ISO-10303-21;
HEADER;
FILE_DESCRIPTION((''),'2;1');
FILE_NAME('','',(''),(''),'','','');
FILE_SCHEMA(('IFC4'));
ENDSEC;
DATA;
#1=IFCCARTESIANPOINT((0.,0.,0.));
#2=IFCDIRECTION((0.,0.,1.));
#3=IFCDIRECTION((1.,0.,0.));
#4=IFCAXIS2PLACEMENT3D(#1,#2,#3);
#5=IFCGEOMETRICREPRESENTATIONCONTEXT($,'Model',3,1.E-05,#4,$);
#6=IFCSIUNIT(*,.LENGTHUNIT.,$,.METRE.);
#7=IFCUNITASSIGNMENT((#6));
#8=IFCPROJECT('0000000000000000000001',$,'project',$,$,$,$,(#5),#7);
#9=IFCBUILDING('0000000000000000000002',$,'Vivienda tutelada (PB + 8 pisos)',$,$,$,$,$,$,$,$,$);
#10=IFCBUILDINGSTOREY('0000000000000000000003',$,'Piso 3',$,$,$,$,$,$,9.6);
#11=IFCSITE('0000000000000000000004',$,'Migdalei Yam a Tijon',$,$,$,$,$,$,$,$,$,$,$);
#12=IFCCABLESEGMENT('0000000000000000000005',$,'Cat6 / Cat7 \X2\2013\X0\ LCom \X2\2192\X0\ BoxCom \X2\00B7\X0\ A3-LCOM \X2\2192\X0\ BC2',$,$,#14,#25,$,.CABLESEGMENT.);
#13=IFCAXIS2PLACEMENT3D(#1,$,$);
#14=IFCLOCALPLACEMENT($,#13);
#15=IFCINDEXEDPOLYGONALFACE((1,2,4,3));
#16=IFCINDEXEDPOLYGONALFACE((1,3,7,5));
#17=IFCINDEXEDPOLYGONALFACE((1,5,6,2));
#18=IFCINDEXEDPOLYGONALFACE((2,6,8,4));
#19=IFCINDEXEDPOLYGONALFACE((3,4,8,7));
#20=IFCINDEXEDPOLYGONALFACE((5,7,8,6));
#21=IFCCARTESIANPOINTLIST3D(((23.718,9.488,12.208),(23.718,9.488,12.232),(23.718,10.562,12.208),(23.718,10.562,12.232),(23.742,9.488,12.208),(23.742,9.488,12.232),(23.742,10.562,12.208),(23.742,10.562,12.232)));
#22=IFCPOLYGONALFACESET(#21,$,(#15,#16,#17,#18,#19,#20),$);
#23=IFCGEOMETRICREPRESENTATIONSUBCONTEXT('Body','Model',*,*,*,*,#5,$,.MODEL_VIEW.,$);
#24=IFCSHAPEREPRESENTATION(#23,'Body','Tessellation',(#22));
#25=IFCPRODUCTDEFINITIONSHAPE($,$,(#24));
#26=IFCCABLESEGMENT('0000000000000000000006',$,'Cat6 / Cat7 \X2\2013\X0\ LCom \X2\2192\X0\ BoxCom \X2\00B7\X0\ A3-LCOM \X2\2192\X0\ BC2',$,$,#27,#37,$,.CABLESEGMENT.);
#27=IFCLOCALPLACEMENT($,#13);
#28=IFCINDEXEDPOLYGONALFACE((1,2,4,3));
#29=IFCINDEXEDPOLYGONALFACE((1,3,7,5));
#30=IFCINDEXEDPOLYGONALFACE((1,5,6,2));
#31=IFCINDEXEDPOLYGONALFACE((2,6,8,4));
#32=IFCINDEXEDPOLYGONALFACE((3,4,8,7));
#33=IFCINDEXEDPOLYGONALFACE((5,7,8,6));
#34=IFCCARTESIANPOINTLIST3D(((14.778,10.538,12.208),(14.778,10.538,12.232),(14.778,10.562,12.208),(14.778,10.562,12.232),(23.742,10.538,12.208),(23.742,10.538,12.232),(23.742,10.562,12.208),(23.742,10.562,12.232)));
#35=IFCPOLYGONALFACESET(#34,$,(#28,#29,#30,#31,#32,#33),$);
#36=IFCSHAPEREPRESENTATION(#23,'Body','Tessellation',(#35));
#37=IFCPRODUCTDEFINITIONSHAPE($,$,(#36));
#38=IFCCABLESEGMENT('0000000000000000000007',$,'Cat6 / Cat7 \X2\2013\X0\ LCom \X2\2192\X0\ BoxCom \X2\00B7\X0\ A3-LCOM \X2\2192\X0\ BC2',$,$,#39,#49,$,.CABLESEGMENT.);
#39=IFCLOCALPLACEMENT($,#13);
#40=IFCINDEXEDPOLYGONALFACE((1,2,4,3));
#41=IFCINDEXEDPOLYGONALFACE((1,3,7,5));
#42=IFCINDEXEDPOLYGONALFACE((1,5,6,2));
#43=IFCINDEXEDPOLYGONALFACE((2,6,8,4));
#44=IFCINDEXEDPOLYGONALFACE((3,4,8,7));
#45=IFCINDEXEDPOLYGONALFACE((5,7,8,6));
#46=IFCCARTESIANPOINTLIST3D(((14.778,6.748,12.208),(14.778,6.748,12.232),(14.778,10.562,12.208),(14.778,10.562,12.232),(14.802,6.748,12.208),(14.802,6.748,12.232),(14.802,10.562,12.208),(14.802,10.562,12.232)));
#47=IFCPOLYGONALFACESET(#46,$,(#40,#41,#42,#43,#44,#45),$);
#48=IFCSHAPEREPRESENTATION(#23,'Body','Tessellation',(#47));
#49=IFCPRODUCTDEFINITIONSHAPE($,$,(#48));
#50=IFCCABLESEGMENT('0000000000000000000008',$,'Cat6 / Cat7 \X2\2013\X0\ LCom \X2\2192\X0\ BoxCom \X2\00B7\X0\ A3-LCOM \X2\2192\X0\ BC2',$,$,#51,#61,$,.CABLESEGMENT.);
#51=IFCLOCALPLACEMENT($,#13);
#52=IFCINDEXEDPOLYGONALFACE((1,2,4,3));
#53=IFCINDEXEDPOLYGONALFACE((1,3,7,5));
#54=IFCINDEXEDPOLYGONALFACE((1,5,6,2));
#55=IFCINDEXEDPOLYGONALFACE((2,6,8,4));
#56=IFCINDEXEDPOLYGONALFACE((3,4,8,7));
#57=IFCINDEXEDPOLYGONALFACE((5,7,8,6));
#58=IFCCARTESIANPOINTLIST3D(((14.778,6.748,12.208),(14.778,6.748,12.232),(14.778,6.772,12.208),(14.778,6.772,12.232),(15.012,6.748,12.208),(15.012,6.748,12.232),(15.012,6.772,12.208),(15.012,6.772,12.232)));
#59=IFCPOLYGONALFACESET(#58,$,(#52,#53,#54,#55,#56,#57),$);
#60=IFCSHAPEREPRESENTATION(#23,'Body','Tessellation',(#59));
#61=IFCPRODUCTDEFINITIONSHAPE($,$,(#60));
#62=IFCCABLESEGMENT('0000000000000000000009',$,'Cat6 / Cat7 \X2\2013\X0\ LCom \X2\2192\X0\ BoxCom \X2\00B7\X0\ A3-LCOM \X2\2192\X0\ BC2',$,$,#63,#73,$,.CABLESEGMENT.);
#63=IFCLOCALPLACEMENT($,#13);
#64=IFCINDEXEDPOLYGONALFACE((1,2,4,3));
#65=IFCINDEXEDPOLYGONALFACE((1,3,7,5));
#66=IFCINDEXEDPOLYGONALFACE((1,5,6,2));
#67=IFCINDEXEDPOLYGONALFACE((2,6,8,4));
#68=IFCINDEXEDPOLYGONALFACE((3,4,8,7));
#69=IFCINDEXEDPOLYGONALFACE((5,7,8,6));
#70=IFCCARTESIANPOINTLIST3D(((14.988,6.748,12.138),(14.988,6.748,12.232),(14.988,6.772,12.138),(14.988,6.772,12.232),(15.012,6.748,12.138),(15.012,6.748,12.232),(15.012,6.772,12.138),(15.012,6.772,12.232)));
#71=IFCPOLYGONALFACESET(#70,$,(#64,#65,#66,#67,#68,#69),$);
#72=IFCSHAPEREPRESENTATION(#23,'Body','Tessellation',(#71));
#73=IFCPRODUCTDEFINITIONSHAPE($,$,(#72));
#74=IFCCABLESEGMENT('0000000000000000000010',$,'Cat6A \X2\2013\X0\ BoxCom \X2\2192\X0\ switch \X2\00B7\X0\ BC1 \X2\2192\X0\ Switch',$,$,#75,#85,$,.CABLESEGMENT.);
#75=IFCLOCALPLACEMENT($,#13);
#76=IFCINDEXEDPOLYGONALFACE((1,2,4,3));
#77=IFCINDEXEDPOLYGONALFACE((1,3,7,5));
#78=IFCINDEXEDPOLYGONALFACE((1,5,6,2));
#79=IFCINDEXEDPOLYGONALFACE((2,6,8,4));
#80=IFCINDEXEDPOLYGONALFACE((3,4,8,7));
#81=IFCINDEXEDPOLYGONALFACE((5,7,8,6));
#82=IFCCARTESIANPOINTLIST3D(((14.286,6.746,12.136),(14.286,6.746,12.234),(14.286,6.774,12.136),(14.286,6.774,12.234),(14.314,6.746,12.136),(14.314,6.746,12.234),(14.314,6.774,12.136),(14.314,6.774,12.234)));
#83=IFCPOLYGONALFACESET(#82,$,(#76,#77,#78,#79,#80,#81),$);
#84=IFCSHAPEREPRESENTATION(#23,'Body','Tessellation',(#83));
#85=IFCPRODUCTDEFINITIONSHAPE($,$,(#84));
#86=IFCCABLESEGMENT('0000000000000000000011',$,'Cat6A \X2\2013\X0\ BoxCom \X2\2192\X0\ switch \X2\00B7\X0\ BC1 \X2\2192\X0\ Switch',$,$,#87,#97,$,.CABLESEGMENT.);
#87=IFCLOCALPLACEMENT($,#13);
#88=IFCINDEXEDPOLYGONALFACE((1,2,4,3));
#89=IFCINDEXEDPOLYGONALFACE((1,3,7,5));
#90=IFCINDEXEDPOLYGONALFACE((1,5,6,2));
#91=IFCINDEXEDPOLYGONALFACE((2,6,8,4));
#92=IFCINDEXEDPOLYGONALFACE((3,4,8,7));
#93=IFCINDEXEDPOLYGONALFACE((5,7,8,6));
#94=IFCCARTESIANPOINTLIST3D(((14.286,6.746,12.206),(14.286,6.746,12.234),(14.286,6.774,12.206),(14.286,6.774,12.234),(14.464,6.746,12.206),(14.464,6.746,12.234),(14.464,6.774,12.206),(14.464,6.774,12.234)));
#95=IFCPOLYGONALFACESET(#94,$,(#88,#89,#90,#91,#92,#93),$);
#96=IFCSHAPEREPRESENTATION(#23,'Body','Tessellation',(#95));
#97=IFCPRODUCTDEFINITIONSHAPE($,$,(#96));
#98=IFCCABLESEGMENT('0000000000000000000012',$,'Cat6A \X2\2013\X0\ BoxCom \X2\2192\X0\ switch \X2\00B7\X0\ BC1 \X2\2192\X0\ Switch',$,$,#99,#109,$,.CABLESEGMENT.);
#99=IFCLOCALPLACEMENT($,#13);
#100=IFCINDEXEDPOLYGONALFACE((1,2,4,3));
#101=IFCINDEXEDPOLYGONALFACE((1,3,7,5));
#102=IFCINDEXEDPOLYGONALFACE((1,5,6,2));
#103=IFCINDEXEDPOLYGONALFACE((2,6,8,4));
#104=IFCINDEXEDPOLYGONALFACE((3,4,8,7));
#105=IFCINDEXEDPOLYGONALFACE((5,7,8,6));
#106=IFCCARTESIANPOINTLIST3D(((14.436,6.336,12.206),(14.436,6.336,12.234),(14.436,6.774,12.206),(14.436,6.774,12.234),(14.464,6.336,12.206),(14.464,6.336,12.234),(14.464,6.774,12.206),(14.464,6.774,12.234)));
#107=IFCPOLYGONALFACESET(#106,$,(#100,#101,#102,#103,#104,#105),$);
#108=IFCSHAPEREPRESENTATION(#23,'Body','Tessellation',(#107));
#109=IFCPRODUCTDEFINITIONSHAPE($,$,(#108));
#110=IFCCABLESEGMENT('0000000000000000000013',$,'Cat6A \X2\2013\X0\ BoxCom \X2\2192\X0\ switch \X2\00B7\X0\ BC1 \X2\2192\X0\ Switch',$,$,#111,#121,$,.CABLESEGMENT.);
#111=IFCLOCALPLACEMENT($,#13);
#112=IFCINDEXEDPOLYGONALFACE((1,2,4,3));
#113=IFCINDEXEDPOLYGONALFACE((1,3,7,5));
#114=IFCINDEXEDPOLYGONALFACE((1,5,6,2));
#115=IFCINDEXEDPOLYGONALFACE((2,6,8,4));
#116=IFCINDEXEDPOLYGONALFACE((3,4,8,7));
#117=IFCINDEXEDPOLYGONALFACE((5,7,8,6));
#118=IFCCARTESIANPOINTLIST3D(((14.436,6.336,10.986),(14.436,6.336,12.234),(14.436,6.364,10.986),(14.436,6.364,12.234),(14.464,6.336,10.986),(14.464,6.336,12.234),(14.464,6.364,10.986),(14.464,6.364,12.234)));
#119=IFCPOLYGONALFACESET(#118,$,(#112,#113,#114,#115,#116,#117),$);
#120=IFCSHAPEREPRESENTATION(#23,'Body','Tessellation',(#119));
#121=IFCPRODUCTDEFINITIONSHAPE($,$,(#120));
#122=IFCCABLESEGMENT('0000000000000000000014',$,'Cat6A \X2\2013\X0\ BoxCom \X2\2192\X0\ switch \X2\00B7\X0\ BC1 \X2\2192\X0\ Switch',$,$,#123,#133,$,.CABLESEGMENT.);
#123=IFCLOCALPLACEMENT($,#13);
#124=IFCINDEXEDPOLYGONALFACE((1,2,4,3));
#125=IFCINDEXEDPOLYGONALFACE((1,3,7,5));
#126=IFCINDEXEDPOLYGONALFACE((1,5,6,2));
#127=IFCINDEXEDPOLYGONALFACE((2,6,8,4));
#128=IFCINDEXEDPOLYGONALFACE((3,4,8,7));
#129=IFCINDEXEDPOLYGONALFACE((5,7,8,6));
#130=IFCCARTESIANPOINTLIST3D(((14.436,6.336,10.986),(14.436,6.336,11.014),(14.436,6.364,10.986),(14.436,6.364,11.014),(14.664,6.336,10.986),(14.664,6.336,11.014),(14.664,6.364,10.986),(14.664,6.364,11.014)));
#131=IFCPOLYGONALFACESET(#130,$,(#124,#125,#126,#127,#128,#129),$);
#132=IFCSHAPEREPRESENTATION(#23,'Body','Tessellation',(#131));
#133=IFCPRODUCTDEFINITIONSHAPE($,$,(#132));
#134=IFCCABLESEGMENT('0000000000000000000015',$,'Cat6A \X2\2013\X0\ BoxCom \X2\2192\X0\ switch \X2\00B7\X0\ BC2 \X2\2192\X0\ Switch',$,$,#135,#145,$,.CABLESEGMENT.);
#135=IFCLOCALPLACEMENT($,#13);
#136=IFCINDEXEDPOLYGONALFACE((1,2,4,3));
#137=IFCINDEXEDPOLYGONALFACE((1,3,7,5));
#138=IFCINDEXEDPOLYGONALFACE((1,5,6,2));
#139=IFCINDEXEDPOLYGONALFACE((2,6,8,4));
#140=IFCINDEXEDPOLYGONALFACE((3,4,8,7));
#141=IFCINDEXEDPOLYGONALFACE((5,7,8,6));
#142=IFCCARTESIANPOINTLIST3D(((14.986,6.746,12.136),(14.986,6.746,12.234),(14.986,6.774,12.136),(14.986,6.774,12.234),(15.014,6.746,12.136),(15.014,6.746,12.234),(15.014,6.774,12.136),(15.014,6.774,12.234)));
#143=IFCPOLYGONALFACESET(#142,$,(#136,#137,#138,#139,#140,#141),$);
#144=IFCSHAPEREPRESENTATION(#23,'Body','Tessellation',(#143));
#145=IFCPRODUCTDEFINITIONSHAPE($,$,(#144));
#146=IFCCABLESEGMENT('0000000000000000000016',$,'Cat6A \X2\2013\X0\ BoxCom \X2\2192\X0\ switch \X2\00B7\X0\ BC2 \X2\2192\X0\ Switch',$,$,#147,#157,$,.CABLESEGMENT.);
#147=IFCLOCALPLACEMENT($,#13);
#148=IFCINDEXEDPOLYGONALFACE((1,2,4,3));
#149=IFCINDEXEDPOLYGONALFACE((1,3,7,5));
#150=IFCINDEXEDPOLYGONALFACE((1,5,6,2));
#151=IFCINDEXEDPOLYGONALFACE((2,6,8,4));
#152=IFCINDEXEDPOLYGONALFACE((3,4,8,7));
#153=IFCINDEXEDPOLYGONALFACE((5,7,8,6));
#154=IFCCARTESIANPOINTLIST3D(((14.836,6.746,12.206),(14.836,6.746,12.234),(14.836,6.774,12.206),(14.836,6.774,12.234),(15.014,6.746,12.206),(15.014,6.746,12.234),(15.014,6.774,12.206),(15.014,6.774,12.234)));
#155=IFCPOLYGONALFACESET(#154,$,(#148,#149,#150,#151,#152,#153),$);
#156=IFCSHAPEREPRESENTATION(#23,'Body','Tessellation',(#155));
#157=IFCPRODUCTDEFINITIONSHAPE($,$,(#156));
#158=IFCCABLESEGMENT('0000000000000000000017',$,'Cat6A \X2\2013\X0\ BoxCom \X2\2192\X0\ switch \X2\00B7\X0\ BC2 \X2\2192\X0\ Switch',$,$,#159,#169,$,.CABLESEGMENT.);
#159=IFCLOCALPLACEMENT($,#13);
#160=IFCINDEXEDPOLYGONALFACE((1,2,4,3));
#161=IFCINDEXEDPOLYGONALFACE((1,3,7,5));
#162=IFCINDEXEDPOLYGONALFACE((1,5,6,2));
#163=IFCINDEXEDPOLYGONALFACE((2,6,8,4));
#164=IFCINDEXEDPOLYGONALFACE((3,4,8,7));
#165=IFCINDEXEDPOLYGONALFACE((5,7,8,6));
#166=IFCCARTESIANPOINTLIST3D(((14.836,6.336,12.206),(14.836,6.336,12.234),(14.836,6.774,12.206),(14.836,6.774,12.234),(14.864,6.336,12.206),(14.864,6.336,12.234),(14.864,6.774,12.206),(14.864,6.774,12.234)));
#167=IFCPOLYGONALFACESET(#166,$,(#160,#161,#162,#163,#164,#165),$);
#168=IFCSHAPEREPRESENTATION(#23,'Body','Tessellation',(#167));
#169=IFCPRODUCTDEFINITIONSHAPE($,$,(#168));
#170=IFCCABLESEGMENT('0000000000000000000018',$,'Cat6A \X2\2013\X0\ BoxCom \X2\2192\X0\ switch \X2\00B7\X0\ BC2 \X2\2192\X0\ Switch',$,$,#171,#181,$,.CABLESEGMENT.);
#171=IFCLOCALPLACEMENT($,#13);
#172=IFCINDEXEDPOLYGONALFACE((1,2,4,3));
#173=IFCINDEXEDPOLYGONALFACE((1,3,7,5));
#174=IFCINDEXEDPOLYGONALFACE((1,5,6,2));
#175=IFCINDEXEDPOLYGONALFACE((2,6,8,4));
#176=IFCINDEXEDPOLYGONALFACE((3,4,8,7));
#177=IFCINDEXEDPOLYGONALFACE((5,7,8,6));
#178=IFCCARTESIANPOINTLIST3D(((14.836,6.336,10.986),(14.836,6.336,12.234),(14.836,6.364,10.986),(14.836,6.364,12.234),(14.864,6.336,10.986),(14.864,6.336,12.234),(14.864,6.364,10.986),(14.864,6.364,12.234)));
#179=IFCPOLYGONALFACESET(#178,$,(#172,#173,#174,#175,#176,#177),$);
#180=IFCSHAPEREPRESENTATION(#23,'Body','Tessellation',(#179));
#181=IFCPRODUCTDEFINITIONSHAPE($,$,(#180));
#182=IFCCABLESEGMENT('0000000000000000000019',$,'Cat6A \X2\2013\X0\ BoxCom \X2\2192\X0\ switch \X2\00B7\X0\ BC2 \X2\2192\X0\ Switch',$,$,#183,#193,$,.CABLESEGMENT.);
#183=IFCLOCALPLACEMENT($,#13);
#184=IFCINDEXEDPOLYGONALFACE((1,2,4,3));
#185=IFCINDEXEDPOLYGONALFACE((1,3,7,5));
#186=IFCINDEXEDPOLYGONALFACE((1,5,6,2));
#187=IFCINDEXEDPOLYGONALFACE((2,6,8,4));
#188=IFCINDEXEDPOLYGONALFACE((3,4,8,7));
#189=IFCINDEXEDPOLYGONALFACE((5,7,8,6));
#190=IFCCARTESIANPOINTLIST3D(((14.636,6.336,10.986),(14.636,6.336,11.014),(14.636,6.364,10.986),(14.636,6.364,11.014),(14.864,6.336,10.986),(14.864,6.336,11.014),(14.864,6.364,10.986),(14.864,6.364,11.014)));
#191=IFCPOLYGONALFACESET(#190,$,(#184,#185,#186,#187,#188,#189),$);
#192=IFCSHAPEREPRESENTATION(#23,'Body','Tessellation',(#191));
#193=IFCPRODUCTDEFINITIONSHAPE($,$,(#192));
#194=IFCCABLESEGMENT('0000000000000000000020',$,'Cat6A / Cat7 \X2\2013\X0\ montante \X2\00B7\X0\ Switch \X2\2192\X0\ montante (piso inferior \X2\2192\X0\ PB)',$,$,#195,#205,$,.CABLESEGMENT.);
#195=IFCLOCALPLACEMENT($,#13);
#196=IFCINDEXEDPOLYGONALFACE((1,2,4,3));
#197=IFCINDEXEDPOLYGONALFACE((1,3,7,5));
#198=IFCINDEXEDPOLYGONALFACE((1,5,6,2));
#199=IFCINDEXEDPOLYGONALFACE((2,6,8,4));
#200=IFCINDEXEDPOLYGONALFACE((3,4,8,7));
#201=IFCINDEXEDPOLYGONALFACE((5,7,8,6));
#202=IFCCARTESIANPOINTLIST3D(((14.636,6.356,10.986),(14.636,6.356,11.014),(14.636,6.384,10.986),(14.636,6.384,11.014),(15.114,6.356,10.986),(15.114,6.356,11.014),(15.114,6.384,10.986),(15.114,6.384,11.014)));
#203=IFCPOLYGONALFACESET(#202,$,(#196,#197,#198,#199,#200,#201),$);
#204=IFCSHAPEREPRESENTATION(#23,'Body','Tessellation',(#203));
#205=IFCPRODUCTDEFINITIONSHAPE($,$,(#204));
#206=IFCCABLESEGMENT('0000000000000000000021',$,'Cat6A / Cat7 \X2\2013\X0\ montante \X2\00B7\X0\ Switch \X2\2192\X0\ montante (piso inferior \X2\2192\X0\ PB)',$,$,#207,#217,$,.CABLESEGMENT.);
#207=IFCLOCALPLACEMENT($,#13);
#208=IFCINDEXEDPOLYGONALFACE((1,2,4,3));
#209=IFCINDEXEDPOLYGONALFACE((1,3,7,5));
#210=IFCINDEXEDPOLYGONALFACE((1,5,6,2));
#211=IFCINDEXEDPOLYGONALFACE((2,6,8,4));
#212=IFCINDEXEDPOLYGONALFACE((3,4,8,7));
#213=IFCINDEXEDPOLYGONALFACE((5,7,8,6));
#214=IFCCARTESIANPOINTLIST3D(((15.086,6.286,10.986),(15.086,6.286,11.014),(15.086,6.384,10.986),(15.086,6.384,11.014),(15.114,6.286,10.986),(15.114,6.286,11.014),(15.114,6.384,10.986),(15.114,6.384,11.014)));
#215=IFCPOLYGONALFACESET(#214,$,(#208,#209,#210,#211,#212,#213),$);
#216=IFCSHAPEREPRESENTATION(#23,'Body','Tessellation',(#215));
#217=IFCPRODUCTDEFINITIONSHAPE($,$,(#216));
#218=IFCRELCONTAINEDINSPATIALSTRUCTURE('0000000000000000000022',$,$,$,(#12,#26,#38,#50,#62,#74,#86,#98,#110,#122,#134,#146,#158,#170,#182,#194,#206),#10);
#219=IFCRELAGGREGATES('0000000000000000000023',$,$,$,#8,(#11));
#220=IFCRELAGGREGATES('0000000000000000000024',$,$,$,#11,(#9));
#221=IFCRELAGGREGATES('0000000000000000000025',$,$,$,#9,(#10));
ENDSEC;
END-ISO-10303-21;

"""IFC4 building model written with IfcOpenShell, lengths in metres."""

from ifc_helpers import new_model, si_unit, frame, origin_with_axes, context, subcontext, project, spatial, line, indexed_curve, outline, extrude, element, save


model = new_model("IFC4")

# Units and contexts
model_context = context("Model", 3, precision=1e-05, world=origin_with_axes())
body_context = subcontext(model_context, "Body", "Model", "MODEL_VIEW")
ifc_project = project(units=[si_unit("LENGTHUNIT", "METRE")], contexts=[model_context])

# Site, building, storey
site = spatial("IfcSite", under=ifc_project, Name="Migdalei Yam a Tijon")
building = spatial("IfcBuilding", under=site, Name="Vivienda tutelada (PB + 8 pisos)")
storey = spatial("IfcBuildingStorey", under=building, Name="Piso 3", Elevation=9.6)

# Cable segments
element("IfcCableSegment", 1, inside=storey, Name="Cat6 / Cat7 – LCom → BoxCom · A3-LCOM → BC2", PredefinedType="CABLESEGMENT", context=body_context, shape_type="SweptSolid", body=[
    extrude(outline(indexed_curve([(0.0, 0.0), (0.024, 0.0), (0.024, 1.074), (0.0, 1.074)], segments=[line(1, 2, 3, 4, 1)])), frame((23.718, 9.488, 12.208), z_axis=(0.0, 0.0, 1.0), x_axis=(1.0, 0.0, 0.0)), (0.0, 0.0, 1.0), 0.024),
])
element("IfcCableSegment", 2, inside=storey, Name="Cat6 / Cat7 – LCom → BoxCom · A3-LCOM → BC2", PredefinedType="CABLESEGMENT", context=body_context, shape_type="SweptSolid", body=[
    extrude(outline(indexed_curve([(0.0, 0.0), (8.964, 0.0), (8.964, 0.024), (0.0, 0.024)], segments=[line(1, 2, 3, 4, 1)])), frame((14.778, 10.538, 12.208), z_axis=(0.0, 0.0, 1.0), x_axis=(1.0, 0.0, 0.0)), (0.0, 0.0, 1.0), 0.024),
])
element("IfcCableSegment", 3, inside=storey, Name="Cat6 / Cat7 – LCom → BoxCom · A3-LCOM → BC2", PredefinedType="CABLESEGMENT", context=body_context, shape_type="SweptSolid", body=[
    extrude(outline(indexed_curve([(0.0, 0.0), (0.024, 0.0), (0.024, 3.814), (0.0, 3.814)], segments=[line(1, 2, 3, 4, 1)])), frame((14.778, 6.748, 12.208), z_axis=(0.0, 0.0, 1.0), x_axis=(1.0, 0.0, 0.0)), (0.0, 0.0, 1.0), 0.024),
])
element("IfcCableSegment", 4, inside=storey, Name="Cat6 / Cat7 – LCom → BoxCom · A3-LCOM → BC2", PredefinedType="CABLESEGMENT", context=body_context, shape_type="SweptSolid", body=[
    extrude(outline(indexed_curve([(0.0, 0.0), (0.234, 0.0), (0.234, 0.024), (0.0, 0.024)], segments=[line(1, 2, 3, 4, 1)])), frame((14.778, 6.748, 12.208), z_axis=(0.0, 0.0, 1.0), x_axis=(1.0, 0.0, 0.0)), (0.0, 0.0, 1.0), 0.024),
])
element("IfcCableSegment", 5, inside=storey, Name="Cat6 / Cat7 – LCom → BoxCom · A3-LCOM → BC2", PredefinedType="CABLESEGMENT", context=body_context, shape_type="SweptSolid", body=[
    extrude(outline(indexed_curve([(0.0, 0.0), (0.024, 0.0), (0.024, 0.024), (0.0, 0.024)], segments=[line(1, 2, 3, 4, 1)])), frame((14.988, 6.748, 12.138), z_axis=(0.0, 0.0, 1.0), x_axis=(1.0, 0.0, 0.0)), (0.0, 0.0, 1.0), 0.094),
])
element("IfcCableSegment", 6, inside=storey, Name="Cat6A – BoxCom → switch · BC1 → Switch", PredefinedType="CABLESEGMENT", context=body_context, shape_type="SweptSolid", body=[
    extrude(outline(indexed_curve([(0.0, 0.0), (0.028, 0.0), (0.028, 0.028), (0.0, 0.028)], segments=[line(1, 2, 3, 4, 1)])), frame((14.286, 6.746, 12.136), z_axis=(0.0, 0.0, 1.0), x_axis=(1.0, 0.0, 0.0)), (0.0, 0.0, 1.0), 0.098),
])
element("IfcCableSegment", 7, inside=storey, Name="Cat6A – BoxCom → switch · BC1 → Switch", PredefinedType="CABLESEGMENT", context=body_context, shape_type="SweptSolid", body=[
    extrude(outline(indexed_curve([(0.0, 0.0), (0.178, 0.0), (0.178, 0.028), (0.0, 0.028)], segments=[line(1, 2, 3, 4, 1)])), frame((14.286, 6.746, 12.206), z_axis=(0.0, 0.0, 1.0), x_axis=(1.0, 0.0, 0.0)), (0.0, 0.0, 1.0), 0.028),
])
element("IfcCableSegment", 8, inside=storey, Name="Cat6A – BoxCom → switch · BC1 → Switch", PredefinedType="CABLESEGMENT", context=body_context, shape_type="SweptSolid", body=[
    extrude(outline(indexed_curve([(0.0, 0.0), (0.028, 0.0), (0.028, 0.438), (0.0, 0.438)], segments=[line(1, 2, 3, 4, 1)])), frame((14.436, 6.336, 12.206), z_axis=(0.0, 0.0, 1.0), x_axis=(1.0, 0.0, 0.0)), (0.0, 0.0, 1.0), 0.028),
])
element("IfcCableSegment", 9, inside=storey, Name="Cat6A – BoxCom → switch · BC1 → Switch", PredefinedType="CABLESEGMENT", context=body_context, shape_type="SweptSolid", body=[
    extrude(outline(indexed_curve([(0.0, 0.0), (0.028, 0.0), (0.028, 0.028), (0.0, 0.028)], segments=[line(1, 2, 3, 4, 1)])), frame((14.436, 6.336, 10.986), z_axis=(0.0, 0.0, 1.0), x_axis=(1.0, 0.0, 0.0)), (0.0, 0.0, 1.0), 1.248),
])
element("IfcCableSegment", 10, inside=storey, Name="Cat6A – BoxCom → switch · BC1 → Switch", PredefinedType="CABLESEGMENT", context=body_context, shape_type="SweptSolid", body=[
    extrude(outline(indexed_curve([(0.0, 0.0), (0.228, 0.0), (0.228, 0.028), (0.0, 0.028)], segments=[line(1, 2, 3, 4, 1)])), frame((14.436, 6.336, 10.986), z_axis=(0.0, 0.0, 1.0), x_axis=(1.0, 0.0, 0.0)), (0.0, 0.0, 1.0), 0.028),
])
element("IfcCableSegment", 11, inside=storey, Name="Cat6A – BoxCom → switch · BC2 → Switch", PredefinedType="CABLESEGMENT", context=body_context, shape_type="SweptSolid", body=[
    extrude(outline(indexed_curve([(0.0, 0.0), (0.028, 0.0), (0.028, 0.028), (0.0, 0.028)], segments=[line(1, 2, 3, 4, 1)])), frame((14.986, 6.746, 12.136), z_axis=(0.0, 0.0, 1.0), x_axis=(1.0, 0.0, 0.0)), (0.0, 0.0, 1.0), 0.098),
])
element("IfcCableSegment", 12, inside=storey, Name="Cat6A – BoxCom → switch · BC2 → Switch", PredefinedType="CABLESEGMENT", context=body_context, shape_type="SweptSolid", body=[
    extrude(outline(indexed_curve([(0.0, 0.0), (0.178, 0.0), (0.178, 0.028), (0.0, 0.028)], segments=[line(1, 2, 3, 4, 1)])), frame((14.836, 6.746, 12.206), z_axis=(0.0, 0.0, 1.0), x_axis=(1.0, 0.0, 0.0)), (0.0, 0.0, 1.0), 0.028),
])
element("IfcCableSegment", 13, inside=storey, Name="Cat6A – BoxCom → switch · BC2 → Switch", PredefinedType="CABLESEGMENT", context=body_context, shape_type="SweptSolid", body=[
    extrude(outline(indexed_curve([(0.0, 0.0), (0.028, 0.0), (0.028, 0.438), (0.0, 0.438)], segments=[line(1, 2, 3, 4, 1)])), frame((14.836, 6.336, 12.206), z_axis=(0.0, 0.0, 1.0), x_axis=(1.0, 0.0, 0.0)), (0.0, 0.0, 1.0), 0.028),
])
element("IfcCableSegment", 14, inside=storey, Name="Cat6A – BoxCom → switch · BC2 → Switch", PredefinedType="CABLESEGMENT", context=body_context, shape_type="SweptSolid", body=[
    extrude(outline(indexed_curve([(0.0, 0.0), (0.028, 0.0), (0.028, 0.028), (0.0, 0.028)], segments=[line(1, 2, 3, 4, 1)])), frame((14.836, 6.336, 10.986), z_axis=(0.0, 0.0, 1.0), x_axis=(1.0, 0.0, 0.0)), (0.0, 0.0, 1.0), 1.248),
])
element("IfcCableSegment", 15, inside=storey, Name="Cat6A – BoxCom → switch · BC2 → Switch", PredefinedType="CABLESEGMENT", context=body_context, shape_type="SweptSolid", body=[
    extrude(outline(indexed_curve([(0.0, 0.0), (0.228, 0.0), (0.228, 0.028), (0.0, 0.028)], segments=[line(1, 2, 3, 4, 1)])), frame((14.636, 6.336, 10.986), z_axis=(0.0, 0.0, 1.0), x_axis=(1.0, 0.0, 0.0)), (0.0, 0.0, 1.0), 0.028),
])
element("IfcCableSegment", 16, inside=storey, Name="Cat6A / Cat7 – montante · Switch → montante (piso inferior → PB)", PredefinedType="CABLESEGMENT", context=body_context, shape_type="SweptSolid", body=[
    extrude(outline(indexed_curve([(0.0, 0.0), (0.478, 0.0), (0.478, 0.028), (0.0, 0.028)], segments=[line(1, 2, 3, 4, 1)])), frame((14.636, 6.356, 10.986), z_axis=(0.0, 0.0, 1.0), x_axis=(1.0, 0.0, 0.0)), (0.0, 0.0, 1.0), 0.028),
])
element("IfcCableSegment", 17, inside=storey, Name="Cat6A / Cat7 – montante · Switch → montante (piso inferior → PB)", PredefinedType="CABLESEGMENT", context=body_context, shape_type="SweptSolid", body=[
    extrude(outline(indexed_curve([(0.0, 0.0), (0.028, 0.0), (0.028, 0.098), (0.0, 0.098)], segments=[line(1, 2, 3, 4, 1)])), frame((15.086, 6.286, 10.986), z_axis=(0.0, 0.0, 1.0), x_axis=(1.0, 0.0, 0.0)), (0.0, 0.0, 1.0), 0.028),
])

save(model, "model.ifc")
